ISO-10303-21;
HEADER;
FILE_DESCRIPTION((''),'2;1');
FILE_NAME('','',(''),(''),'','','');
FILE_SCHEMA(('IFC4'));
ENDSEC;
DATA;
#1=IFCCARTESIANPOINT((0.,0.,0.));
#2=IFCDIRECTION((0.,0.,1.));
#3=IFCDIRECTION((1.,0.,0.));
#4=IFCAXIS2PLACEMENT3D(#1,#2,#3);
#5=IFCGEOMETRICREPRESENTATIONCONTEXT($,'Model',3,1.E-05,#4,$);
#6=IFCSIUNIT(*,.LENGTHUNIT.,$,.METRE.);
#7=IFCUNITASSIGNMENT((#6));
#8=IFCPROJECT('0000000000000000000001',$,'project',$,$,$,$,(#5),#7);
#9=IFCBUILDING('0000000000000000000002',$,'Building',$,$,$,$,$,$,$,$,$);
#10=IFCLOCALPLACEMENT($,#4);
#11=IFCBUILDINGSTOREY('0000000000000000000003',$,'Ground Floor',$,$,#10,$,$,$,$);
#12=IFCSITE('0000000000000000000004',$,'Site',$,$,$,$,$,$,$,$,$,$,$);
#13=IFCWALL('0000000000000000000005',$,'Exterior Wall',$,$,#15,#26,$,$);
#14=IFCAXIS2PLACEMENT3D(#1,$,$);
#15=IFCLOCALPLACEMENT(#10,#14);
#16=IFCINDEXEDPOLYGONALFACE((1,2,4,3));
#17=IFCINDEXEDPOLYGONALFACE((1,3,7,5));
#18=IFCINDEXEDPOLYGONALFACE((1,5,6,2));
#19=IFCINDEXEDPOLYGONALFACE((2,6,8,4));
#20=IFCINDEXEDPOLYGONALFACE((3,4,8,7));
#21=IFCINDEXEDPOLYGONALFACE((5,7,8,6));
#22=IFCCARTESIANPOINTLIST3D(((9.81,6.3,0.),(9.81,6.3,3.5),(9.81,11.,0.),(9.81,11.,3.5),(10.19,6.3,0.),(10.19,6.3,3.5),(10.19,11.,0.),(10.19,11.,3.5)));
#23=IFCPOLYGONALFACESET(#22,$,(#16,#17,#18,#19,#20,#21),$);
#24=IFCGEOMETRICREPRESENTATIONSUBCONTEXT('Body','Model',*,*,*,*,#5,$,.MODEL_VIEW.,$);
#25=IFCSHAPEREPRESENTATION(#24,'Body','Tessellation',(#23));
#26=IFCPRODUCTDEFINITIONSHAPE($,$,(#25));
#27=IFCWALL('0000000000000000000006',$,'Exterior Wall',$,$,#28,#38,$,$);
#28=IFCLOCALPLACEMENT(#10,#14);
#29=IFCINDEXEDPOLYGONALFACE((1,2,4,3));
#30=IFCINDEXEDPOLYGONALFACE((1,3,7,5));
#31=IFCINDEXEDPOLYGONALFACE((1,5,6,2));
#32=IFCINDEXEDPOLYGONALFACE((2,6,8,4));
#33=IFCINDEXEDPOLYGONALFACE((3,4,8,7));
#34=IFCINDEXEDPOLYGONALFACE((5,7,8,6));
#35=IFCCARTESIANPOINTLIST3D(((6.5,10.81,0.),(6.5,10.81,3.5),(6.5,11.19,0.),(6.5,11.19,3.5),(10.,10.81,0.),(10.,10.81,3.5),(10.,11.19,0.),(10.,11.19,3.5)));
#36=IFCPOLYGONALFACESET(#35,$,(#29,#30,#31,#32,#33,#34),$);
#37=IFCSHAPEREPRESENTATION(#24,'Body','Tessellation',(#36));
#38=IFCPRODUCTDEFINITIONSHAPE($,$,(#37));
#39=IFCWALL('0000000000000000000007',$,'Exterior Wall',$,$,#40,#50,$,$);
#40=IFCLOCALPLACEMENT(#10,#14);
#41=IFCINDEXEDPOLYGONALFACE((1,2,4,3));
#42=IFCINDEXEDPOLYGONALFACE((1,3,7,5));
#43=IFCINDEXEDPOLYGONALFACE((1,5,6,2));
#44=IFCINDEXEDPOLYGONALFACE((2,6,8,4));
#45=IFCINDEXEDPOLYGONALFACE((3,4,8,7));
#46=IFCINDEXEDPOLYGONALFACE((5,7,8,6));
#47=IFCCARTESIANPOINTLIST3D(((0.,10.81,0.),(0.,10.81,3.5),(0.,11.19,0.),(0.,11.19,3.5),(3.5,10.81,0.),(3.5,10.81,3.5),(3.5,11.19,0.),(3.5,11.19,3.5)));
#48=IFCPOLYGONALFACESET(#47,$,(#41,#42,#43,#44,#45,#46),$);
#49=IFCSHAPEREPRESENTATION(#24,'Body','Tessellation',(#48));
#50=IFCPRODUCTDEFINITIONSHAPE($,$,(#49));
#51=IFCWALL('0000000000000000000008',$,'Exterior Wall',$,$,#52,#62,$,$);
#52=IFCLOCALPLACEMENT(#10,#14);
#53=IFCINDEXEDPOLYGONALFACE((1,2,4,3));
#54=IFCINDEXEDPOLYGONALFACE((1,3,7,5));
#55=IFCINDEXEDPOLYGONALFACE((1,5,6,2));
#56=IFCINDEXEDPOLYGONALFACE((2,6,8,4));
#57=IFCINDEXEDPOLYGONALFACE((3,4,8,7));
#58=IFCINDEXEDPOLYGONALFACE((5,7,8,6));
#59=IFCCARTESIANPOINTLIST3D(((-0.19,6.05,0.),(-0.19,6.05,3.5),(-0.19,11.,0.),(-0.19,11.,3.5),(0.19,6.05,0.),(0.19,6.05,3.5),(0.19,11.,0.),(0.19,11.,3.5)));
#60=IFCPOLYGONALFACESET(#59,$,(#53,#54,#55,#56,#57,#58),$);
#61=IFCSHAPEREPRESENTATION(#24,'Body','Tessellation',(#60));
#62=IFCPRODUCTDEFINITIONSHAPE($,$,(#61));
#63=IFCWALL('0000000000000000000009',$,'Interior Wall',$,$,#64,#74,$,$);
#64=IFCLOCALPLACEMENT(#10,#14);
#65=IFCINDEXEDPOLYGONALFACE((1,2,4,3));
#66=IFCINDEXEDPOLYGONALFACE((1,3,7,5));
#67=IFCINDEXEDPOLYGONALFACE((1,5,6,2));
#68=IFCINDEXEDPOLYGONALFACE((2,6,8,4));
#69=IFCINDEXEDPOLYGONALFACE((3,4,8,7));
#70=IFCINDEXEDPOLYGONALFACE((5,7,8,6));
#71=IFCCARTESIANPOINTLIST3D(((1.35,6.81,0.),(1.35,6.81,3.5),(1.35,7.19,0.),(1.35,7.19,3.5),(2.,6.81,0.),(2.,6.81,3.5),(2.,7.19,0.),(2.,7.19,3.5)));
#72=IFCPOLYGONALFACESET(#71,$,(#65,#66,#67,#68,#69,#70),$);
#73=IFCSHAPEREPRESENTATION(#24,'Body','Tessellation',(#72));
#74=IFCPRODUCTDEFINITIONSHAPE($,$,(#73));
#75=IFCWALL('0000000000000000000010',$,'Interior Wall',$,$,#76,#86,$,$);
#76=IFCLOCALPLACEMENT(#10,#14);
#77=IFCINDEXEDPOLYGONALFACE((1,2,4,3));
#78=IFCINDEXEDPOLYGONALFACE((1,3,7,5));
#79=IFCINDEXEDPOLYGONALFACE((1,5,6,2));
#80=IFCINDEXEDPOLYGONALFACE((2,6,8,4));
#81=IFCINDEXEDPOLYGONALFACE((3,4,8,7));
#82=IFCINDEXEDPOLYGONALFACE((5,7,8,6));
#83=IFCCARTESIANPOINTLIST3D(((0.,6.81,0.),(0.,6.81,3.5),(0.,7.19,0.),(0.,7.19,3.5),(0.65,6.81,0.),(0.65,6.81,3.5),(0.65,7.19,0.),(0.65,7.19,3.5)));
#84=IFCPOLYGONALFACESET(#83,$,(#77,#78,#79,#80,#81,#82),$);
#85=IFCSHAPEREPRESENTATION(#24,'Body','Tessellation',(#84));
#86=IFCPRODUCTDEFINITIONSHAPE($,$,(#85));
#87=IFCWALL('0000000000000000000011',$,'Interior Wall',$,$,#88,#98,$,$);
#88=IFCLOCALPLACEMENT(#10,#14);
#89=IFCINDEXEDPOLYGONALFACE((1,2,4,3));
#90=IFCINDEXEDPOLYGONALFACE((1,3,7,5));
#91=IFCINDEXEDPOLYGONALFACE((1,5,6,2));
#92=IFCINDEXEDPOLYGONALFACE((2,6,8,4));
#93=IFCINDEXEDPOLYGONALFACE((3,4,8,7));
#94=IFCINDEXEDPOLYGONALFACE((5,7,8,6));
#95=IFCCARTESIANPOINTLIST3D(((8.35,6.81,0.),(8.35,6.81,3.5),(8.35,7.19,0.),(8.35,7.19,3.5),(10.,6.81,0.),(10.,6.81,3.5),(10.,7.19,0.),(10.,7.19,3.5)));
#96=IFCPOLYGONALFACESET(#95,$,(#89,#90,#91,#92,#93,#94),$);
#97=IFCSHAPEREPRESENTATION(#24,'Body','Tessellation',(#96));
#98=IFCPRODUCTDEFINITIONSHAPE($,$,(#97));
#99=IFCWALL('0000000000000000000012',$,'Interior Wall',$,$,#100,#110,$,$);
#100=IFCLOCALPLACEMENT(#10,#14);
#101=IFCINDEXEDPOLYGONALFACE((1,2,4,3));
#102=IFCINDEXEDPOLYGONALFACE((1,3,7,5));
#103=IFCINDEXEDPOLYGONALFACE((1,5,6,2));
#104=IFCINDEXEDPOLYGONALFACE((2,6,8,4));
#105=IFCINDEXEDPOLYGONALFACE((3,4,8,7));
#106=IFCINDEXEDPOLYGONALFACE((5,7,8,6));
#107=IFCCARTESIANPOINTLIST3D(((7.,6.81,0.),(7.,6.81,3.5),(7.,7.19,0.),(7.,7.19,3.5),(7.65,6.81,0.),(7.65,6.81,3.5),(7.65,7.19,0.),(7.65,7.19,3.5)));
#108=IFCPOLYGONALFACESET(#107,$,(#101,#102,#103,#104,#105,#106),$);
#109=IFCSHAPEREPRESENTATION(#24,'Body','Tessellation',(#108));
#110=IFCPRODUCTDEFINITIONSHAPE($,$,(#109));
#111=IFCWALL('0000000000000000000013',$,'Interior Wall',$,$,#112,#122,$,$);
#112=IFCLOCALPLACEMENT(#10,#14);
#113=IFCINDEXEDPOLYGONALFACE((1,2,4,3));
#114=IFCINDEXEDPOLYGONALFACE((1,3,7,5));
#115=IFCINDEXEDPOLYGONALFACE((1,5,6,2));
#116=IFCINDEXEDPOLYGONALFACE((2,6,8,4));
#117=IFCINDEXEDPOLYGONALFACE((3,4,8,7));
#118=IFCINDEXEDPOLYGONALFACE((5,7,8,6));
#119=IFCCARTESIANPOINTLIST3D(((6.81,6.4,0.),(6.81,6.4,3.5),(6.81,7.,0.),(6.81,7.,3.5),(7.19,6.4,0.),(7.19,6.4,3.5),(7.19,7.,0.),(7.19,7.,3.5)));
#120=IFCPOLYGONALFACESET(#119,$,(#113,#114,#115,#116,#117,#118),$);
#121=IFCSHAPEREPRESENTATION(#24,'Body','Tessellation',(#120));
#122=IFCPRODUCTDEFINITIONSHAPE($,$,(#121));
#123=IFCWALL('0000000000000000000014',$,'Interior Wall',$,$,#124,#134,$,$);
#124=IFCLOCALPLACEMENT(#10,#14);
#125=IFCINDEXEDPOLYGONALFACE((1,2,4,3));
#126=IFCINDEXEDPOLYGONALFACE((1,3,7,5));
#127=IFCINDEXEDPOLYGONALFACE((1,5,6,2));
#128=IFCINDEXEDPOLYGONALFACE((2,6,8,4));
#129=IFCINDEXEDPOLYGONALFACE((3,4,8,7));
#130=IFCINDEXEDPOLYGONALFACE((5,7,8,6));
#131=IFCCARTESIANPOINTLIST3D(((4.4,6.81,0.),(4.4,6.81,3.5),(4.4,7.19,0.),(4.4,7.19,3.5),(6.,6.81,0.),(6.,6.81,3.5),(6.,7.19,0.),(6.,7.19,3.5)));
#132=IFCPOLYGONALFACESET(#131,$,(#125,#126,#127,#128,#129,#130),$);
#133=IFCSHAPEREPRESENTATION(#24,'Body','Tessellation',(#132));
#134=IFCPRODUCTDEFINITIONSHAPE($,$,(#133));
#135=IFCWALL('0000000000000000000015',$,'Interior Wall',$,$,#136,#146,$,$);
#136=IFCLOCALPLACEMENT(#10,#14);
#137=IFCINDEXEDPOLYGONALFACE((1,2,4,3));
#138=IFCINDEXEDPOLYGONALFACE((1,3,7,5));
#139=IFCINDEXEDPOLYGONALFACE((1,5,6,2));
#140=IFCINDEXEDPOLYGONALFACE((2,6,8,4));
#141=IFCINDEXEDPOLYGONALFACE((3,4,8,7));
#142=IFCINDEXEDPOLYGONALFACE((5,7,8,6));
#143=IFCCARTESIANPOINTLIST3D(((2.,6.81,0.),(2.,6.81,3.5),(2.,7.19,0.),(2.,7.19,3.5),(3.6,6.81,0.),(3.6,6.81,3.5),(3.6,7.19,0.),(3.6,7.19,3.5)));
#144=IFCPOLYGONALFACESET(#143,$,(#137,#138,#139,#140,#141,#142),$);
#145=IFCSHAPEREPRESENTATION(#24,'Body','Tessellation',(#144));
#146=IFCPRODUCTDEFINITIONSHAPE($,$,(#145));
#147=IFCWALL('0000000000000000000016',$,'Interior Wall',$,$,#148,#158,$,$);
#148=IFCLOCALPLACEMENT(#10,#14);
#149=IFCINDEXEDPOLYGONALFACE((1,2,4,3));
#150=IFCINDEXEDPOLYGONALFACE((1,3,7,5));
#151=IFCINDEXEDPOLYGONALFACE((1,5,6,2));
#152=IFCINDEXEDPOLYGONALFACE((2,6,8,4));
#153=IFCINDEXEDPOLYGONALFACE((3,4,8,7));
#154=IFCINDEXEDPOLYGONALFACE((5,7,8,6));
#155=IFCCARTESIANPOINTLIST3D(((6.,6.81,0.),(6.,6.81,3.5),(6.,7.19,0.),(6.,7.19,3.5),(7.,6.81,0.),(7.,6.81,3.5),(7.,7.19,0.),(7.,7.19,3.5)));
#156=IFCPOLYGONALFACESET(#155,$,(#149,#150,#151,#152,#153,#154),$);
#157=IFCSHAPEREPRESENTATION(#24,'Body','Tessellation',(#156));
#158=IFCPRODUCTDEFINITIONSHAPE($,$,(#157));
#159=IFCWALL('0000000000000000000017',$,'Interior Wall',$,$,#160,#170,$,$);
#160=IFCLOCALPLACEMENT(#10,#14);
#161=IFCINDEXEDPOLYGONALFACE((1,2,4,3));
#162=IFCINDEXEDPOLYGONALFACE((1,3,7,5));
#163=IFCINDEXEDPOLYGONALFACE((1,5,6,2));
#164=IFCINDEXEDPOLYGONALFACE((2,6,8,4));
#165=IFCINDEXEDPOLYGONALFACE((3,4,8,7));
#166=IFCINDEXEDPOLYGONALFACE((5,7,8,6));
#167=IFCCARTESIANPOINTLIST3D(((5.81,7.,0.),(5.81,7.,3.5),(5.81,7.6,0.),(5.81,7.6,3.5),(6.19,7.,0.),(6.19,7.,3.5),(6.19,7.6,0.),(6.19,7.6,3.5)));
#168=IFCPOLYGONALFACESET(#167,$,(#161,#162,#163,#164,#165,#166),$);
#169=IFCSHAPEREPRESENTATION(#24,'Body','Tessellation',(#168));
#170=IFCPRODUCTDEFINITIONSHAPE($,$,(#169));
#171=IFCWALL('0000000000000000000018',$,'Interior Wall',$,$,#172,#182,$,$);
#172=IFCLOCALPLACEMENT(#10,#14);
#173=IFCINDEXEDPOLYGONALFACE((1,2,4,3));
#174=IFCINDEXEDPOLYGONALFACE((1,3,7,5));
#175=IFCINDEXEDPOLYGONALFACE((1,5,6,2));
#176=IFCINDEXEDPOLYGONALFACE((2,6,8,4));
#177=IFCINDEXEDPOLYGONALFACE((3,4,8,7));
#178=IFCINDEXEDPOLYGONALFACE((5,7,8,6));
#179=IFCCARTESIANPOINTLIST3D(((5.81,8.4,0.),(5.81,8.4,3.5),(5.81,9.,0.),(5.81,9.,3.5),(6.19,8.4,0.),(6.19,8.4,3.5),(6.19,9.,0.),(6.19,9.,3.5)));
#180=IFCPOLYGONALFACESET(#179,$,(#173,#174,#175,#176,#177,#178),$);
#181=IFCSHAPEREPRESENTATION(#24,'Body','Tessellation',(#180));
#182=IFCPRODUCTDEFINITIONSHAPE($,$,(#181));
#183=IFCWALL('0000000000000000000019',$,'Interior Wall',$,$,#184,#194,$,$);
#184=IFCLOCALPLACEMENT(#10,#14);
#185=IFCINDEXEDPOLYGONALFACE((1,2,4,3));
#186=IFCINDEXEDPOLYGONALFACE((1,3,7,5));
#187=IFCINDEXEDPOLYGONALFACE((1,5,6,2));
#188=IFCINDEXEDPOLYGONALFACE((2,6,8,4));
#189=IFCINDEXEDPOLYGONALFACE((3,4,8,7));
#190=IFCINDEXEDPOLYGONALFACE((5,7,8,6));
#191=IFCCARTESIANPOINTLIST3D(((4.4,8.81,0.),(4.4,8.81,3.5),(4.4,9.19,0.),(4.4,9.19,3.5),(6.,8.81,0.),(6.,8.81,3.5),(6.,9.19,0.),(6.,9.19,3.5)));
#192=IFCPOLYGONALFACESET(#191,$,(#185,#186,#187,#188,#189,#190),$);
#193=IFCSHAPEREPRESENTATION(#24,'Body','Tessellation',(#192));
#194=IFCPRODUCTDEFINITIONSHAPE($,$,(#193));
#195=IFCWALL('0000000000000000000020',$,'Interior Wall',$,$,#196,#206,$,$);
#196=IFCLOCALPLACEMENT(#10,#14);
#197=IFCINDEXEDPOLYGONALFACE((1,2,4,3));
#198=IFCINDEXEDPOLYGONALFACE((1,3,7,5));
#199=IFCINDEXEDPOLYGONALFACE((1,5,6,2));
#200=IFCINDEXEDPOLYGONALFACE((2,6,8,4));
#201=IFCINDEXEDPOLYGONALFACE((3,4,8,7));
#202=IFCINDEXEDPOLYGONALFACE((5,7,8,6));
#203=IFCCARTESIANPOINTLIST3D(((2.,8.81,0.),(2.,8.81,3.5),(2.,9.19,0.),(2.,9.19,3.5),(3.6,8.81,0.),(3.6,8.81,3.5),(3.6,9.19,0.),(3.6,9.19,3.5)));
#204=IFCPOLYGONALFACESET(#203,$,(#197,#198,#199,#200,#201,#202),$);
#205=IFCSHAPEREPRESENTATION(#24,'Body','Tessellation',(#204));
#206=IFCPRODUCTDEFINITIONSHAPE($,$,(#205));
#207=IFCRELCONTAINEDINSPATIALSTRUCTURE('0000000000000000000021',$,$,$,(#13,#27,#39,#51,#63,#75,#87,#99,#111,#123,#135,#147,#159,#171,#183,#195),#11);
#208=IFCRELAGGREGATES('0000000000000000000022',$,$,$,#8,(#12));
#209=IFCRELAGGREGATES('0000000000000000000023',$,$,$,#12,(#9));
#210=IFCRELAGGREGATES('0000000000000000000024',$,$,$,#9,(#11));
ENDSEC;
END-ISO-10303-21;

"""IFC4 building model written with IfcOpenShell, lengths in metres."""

from ifc_helpers import new_model, si_unit, frame, origin_with_axes, place, context, subcontext, project, spatial, indexed_curve, outline, extrude, element, save


model = new_model("IFC4")

# Units and contexts
model_context = context("Model", 3, precision=1e-05, world=origin_with_axes())
body_context = subcontext(model_context, "Body", "Model", "MODEL_VIEW")
ifc_project = project(units=[si_unit("LENGTHUNIT", "METRE")], contexts=[model_context])

# Site, building, storey
site = spatial("IfcSite", under=ifc_project, Name="Site")
building = spatial("IfcBuilding", under=site, Name="Building")
storey_placement = place(None, origin_with_axes())
storey = spatial("IfcBuildingStorey", under=building, at=storey_placement, Name="Ground Floor")

# Walls
wall_1_placement = place(storey_placement, frame((10.0, 6.3, 0.0), z_axis=(0.0, 0.0, 1.0), x_axis=(0.0, 1.0, 0.0)))
element("IfcWall", 1, at=wall_1_placement, inside=storey, Name="Exterior Wall", context=body_context, shape_type="SweptSolid", body=[
    extrude(outline(indexed_curve([(0.0, 0.0), (0.0, 0.38), (4.7, 0.38), (4.7, 0.0), (0.0, 0.0)], self_intersect=False)), frame((0.0, -0.19, 0.0), z_axis=(0.0, 0.0, 1.0), x_axis=(1.0, 0.0, 0.0)), (0.0, 0.0, 1.0), 3.5),
])
for number, where, z_axis, x_axis, name in (
    (2, (10.0, 11.0, 0.0), (0.0, 0.0, 1.0), (-1.0, 0.0, 0.0), "Exterior Wall"),
    (3, (3.5, 11.0, 0.0), (0.0, 0.0, 1.0), (-1.0, 0.0, 0.0), "Exterior Wall"),
):
    element("IfcWall", number, at=place(storey_placement, frame(where, z_axis=z_axis, x_axis=x_axis)), inside=storey, Name=name, context=body_context, shape_type="SweptSolid", body=[
        extrude(outline(indexed_curve([(0.0, 0.0), (0.0, 0.38), (3.5, 0.38), (3.5, 0.0), (0.0, 0.0)], self_intersect=False)), frame((0.0, -0.19, 0.0), z_axis=(0.0, 0.0, 1.0), x_axis=(1.0, 0.0, 0.0)), (0.0, 0.0, 1.0), 3.5),
    ])
wall_2_placement = place(storey_placement, frame((0.0, 11.0, 0.0), z_axis=(0.0, 0.0, 1.0), x_axis=(0.0, -1.0, 0.0)))
element("IfcWall", 4, at=wall_2_placement, inside=storey, Name="Exterior Wall", context=body_context, shape_type="SweptSolid", body=[
    extrude(outline(indexed_curve([(0.0, 0.0), (0.0, 0.38), (4.95, 0.38), (4.95, 0.0), (0.0, 0.0)], self_intersect=False)), frame((0.0, -0.19, 0.0), z_axis=(0.0, 0.0, 1.0), x_axis=(1.0, 0.0, 0.0)), (0.0, 0.0, 1.0), 3.5),
])
for number, where, z_axis, x_axis, name in (
    (5, (2.0, 7.0, 0.0), (0.0, 0.0, 1.0), (-1.0, 0.0, 0.0), "Interior Wall"),
    (6, (0.65, 7.0, 0.0), (0.0, 0.0, 1.0), (-1.0, 0.0, 0.0), "Interior Wall"),
):
    element("IfcWall", number, at=place(storey_placement, frame(where, z_axis=z_axis, x_axis=x_axis)), inside=storey, Name=name, context=body_context, shape_type="SweptSolid", body=[
        extrude(outline(indexed_curve([(0.0, 0.0), (0.0, 0.38), (0.65, 0.38), (0.65, 0.0), (0.0, 0.0)], self_intersect=False)), frame((0.0, -0.19, 0.0), z_axis=(0.0, 0.0, 1.0), x_axis=(1.0, 0.0, 0.0)), (0.0, 0.0, 1.0), 3.5),
    ])
wall_3_placement = place(storey_placement, frame((10.0, 7.0, 0.0), z_axis=(0.0, 0.0, 1.0), x_axis=(-1.0, 0.0, 0.0)))
element("IfcWall", 7, at=wall_3_placement, inside=storey, Name="Interior Wall", context=body_context, shape_type="SweptSolid", body=[
    extrude(outline(indexed_curve([(0.0, 0.0), (0.0, 0.38), (1.65, 0.38), (1.65, 0.0), (0.0, 0.0)], self_intersect=False)), frame((0.0, -0.19, 0.0), z_axis=(0.0, 0.0, 1.0), x_axis=(1.0, 0.0, 0.0)), (0.0, 0.0, 1.0), 3.5),
])
wall_4_placement = place(storey_placement, frame((7.65, 7.0, 0.0), z_axis=(0.0, 0.0, 1.0), x_axis=(-1.0, 0.0, 0.0)))
element("IfcWall", 8, at=wall_4_placement, inside=storey, Name="Interior Wall", context=body_context, shape_type="SweptSolid", body=[
    extrude(outline(indexed_curve([(0.0, 0.0), (0.0, 0.38), (0.65, 0.38), (0.65, 0.0), (0.0, 0.0)], self_intersect=False)), frame((0.0, -0.19, 0.0), z_axis=(0.0, 0.0, 1.0), x_axis=(1.0, 0.0, 0.0)), (0.0, 0.0, 1.0), 3.5),
])
wall_5_placement = place(storey_placement, frame((7.0, 7.0, 0.0), z_axis=(0.0, 0.0, 1.0), x_axis=(0.0, -1.0, 0.0)))
element("IfcWall", 9, at=wall_5_placement, inside=storey, Name="Interior Wall", context=body_context, shape_type="SweptSolid", body=[
    extrude(outline(indexed_curve([(0.0, 0.0), (0.0, 0.38), (0.6, 0.38), (0.6, 0.0), (0.0, 0.0)], self_intersect=False)), frame((0.0, -0.19, 0.0), z_axis=(0.0, 0.0, 1.0), x_axis=(1.0, 0.0, 0.0)), (0.0, 0.0, 1.0), 3.5),
])
wall_6_placement = place(storey_placement, frame((6.0, 7.0, 0.0), z_axis=(0.0, 0.0, 1.0), x_axis=(-1.0, 0.0, 0.0)))
element("IfcWall", 10, at=wall_6_placement, inside=storey, Name="Interior Wall", context=body_context, shape_type="SweptSolid", body=[
    extrude(outline(indexed_curve([(0.0, 0.0), (0.0, 0.38), (1.6, 0.38), (1.6, 0.0), (0.0, 0.0)], self_intersect=False)), frame((0.0, -0.19, 0.0), z_axis=(0.0, 0.0, 1.0), x_axis=(1.0, 0.0, 0.0)), (0.0, 0.0, 1.0), 3.5),
])
wall_7_placement = place(storey_placement, frame((3.6, 7.0, 0.0), z_axis=(0.0, 0.0, 1.0), x_axis=(-1.0, 0.0, 0.0)))
element("IfcWall", 11, at=wall_7_placement, inside=storey, Name="Interior Wall", context=body_context, shape_type="SweptSolid", body=[
    extrude(outline(indexed_curve([(0.0, 0.0), (0.0, 0.38), (1.6, 0.38), (1.6, 0.0), (0.0, 0.0)], self_intersect=False)), frame((0.0, -0.19, 0.0), z_axis=(0.0, 0.0, 1.0), x_axis=(1.0, 0.0, 0.0)), (0.0, 0.0, 1.0), 3.5),
])
wall_8_placement = place(storey_placement, frame((7.0, 7.0, 0.0), z_axis=(0.0, 0.0, 1.0), x_axis=(-1.0, 0.0, 0.0)))
element("IfcWall", 12, at=wall_8_placement, inside=storey, Name="Interior Wall", context=body_context, shape_type="SweptSolid", body=[
    extrude(outline(indexed_curve([(0.0, 0.0), (0.0, 0.38), (1.0, 0.38), (1.0, 0.0), (0.0, 0.0)], self_intersect=False)), frame((0.0, -0.19, 0.0), z_axis=(0.0, 0.0, 1.0), x_axis=(1.0, 0.0, 0.0)), (0.0, 0.0, 1.0), 3.5),
])
for number, where, z_axis, x_axis, name in (
    (13, (6.0, 7.0, 0.0), (0.0, 0.0, 1.0), (0.0, 1.0, 0.0), "Interior Wall"),
    (14, (6.0, 8.4, 0.0), (0.0, 0.0, 1.0), (0.0, 1.0, 0.0), "Interior Wall"),
):
    element("IfcWall", number, at=place(storey_placement, frame(where, z_axis=z_axis, x_axis=x_axis)), inside=storey, Name=name, context=body_context, shape_type="SweptSolid", body=[
        extrude(outline(indexed_curve([(0.0, 0.0), (0.0, 0.38), (0.6, 0.38), (0.6, 0.0), (0.0, 0.0)], self_intersect=False)), frame((0.0, -0.19, 0.0), z_axis=(0.0, 0.0, 1.0), x_axis=(1.0, 0.0, 0.0)), (0.0, 0.0, 1.0), 3.5),
    ])
wall_9_placement = place(storey_placement, frame((6.0, 9.0, 0.0), z_axis=(0.0, 0.0, 1.0), x_axis=(-1.0, 0.0, 0.0)))
element("IfcWall", 15, at=wall_9_placement, inside=storey, Name="Interior Wall", context=body_context, shape_type="SweptSolid", body=[
    extrude(outline(indexed_curve([(0.0, 0.0), (0.0, 0.38), (1.6, 0.38), (1.6, 0.0), (0.0, 0.0)], self_intersect=False)), frame((0.0, -0.19, 0.0), z_axis=(0.0, 0.0, 1.0), x_axis=(1.0, 0.0, 0.0)), (0.0, 0.0, 1.0), 3.5),
])
wall_10_placement = place(storey_placement, frame((3.6, 9.0, 0.0), z_axis=(0.0, 0.0, 1.0), x_axis=(-1.0, 0.0, 0.0)))
element("IfcWall", 16, at=wall_10_placement, inside=storey, Name="Interior Wall", context=body_context, shape_type="SweptSolid", body=[
    extrude(outline(indexed_curve([(0.0, 0.0), (0.0, 0.38), (1.6, 0.38), (1.6, 0.0), (0.0, 0.0)], self_intersect=False)), frame((0.0, -0.19, 0.0), z_axis=(0.0, 0.0, 1.0), x_axis=(1.0, 0.0, 0.0)), (0.0, 0.0, 1.0), 3.5),
])

save(model, "model.ifc")
